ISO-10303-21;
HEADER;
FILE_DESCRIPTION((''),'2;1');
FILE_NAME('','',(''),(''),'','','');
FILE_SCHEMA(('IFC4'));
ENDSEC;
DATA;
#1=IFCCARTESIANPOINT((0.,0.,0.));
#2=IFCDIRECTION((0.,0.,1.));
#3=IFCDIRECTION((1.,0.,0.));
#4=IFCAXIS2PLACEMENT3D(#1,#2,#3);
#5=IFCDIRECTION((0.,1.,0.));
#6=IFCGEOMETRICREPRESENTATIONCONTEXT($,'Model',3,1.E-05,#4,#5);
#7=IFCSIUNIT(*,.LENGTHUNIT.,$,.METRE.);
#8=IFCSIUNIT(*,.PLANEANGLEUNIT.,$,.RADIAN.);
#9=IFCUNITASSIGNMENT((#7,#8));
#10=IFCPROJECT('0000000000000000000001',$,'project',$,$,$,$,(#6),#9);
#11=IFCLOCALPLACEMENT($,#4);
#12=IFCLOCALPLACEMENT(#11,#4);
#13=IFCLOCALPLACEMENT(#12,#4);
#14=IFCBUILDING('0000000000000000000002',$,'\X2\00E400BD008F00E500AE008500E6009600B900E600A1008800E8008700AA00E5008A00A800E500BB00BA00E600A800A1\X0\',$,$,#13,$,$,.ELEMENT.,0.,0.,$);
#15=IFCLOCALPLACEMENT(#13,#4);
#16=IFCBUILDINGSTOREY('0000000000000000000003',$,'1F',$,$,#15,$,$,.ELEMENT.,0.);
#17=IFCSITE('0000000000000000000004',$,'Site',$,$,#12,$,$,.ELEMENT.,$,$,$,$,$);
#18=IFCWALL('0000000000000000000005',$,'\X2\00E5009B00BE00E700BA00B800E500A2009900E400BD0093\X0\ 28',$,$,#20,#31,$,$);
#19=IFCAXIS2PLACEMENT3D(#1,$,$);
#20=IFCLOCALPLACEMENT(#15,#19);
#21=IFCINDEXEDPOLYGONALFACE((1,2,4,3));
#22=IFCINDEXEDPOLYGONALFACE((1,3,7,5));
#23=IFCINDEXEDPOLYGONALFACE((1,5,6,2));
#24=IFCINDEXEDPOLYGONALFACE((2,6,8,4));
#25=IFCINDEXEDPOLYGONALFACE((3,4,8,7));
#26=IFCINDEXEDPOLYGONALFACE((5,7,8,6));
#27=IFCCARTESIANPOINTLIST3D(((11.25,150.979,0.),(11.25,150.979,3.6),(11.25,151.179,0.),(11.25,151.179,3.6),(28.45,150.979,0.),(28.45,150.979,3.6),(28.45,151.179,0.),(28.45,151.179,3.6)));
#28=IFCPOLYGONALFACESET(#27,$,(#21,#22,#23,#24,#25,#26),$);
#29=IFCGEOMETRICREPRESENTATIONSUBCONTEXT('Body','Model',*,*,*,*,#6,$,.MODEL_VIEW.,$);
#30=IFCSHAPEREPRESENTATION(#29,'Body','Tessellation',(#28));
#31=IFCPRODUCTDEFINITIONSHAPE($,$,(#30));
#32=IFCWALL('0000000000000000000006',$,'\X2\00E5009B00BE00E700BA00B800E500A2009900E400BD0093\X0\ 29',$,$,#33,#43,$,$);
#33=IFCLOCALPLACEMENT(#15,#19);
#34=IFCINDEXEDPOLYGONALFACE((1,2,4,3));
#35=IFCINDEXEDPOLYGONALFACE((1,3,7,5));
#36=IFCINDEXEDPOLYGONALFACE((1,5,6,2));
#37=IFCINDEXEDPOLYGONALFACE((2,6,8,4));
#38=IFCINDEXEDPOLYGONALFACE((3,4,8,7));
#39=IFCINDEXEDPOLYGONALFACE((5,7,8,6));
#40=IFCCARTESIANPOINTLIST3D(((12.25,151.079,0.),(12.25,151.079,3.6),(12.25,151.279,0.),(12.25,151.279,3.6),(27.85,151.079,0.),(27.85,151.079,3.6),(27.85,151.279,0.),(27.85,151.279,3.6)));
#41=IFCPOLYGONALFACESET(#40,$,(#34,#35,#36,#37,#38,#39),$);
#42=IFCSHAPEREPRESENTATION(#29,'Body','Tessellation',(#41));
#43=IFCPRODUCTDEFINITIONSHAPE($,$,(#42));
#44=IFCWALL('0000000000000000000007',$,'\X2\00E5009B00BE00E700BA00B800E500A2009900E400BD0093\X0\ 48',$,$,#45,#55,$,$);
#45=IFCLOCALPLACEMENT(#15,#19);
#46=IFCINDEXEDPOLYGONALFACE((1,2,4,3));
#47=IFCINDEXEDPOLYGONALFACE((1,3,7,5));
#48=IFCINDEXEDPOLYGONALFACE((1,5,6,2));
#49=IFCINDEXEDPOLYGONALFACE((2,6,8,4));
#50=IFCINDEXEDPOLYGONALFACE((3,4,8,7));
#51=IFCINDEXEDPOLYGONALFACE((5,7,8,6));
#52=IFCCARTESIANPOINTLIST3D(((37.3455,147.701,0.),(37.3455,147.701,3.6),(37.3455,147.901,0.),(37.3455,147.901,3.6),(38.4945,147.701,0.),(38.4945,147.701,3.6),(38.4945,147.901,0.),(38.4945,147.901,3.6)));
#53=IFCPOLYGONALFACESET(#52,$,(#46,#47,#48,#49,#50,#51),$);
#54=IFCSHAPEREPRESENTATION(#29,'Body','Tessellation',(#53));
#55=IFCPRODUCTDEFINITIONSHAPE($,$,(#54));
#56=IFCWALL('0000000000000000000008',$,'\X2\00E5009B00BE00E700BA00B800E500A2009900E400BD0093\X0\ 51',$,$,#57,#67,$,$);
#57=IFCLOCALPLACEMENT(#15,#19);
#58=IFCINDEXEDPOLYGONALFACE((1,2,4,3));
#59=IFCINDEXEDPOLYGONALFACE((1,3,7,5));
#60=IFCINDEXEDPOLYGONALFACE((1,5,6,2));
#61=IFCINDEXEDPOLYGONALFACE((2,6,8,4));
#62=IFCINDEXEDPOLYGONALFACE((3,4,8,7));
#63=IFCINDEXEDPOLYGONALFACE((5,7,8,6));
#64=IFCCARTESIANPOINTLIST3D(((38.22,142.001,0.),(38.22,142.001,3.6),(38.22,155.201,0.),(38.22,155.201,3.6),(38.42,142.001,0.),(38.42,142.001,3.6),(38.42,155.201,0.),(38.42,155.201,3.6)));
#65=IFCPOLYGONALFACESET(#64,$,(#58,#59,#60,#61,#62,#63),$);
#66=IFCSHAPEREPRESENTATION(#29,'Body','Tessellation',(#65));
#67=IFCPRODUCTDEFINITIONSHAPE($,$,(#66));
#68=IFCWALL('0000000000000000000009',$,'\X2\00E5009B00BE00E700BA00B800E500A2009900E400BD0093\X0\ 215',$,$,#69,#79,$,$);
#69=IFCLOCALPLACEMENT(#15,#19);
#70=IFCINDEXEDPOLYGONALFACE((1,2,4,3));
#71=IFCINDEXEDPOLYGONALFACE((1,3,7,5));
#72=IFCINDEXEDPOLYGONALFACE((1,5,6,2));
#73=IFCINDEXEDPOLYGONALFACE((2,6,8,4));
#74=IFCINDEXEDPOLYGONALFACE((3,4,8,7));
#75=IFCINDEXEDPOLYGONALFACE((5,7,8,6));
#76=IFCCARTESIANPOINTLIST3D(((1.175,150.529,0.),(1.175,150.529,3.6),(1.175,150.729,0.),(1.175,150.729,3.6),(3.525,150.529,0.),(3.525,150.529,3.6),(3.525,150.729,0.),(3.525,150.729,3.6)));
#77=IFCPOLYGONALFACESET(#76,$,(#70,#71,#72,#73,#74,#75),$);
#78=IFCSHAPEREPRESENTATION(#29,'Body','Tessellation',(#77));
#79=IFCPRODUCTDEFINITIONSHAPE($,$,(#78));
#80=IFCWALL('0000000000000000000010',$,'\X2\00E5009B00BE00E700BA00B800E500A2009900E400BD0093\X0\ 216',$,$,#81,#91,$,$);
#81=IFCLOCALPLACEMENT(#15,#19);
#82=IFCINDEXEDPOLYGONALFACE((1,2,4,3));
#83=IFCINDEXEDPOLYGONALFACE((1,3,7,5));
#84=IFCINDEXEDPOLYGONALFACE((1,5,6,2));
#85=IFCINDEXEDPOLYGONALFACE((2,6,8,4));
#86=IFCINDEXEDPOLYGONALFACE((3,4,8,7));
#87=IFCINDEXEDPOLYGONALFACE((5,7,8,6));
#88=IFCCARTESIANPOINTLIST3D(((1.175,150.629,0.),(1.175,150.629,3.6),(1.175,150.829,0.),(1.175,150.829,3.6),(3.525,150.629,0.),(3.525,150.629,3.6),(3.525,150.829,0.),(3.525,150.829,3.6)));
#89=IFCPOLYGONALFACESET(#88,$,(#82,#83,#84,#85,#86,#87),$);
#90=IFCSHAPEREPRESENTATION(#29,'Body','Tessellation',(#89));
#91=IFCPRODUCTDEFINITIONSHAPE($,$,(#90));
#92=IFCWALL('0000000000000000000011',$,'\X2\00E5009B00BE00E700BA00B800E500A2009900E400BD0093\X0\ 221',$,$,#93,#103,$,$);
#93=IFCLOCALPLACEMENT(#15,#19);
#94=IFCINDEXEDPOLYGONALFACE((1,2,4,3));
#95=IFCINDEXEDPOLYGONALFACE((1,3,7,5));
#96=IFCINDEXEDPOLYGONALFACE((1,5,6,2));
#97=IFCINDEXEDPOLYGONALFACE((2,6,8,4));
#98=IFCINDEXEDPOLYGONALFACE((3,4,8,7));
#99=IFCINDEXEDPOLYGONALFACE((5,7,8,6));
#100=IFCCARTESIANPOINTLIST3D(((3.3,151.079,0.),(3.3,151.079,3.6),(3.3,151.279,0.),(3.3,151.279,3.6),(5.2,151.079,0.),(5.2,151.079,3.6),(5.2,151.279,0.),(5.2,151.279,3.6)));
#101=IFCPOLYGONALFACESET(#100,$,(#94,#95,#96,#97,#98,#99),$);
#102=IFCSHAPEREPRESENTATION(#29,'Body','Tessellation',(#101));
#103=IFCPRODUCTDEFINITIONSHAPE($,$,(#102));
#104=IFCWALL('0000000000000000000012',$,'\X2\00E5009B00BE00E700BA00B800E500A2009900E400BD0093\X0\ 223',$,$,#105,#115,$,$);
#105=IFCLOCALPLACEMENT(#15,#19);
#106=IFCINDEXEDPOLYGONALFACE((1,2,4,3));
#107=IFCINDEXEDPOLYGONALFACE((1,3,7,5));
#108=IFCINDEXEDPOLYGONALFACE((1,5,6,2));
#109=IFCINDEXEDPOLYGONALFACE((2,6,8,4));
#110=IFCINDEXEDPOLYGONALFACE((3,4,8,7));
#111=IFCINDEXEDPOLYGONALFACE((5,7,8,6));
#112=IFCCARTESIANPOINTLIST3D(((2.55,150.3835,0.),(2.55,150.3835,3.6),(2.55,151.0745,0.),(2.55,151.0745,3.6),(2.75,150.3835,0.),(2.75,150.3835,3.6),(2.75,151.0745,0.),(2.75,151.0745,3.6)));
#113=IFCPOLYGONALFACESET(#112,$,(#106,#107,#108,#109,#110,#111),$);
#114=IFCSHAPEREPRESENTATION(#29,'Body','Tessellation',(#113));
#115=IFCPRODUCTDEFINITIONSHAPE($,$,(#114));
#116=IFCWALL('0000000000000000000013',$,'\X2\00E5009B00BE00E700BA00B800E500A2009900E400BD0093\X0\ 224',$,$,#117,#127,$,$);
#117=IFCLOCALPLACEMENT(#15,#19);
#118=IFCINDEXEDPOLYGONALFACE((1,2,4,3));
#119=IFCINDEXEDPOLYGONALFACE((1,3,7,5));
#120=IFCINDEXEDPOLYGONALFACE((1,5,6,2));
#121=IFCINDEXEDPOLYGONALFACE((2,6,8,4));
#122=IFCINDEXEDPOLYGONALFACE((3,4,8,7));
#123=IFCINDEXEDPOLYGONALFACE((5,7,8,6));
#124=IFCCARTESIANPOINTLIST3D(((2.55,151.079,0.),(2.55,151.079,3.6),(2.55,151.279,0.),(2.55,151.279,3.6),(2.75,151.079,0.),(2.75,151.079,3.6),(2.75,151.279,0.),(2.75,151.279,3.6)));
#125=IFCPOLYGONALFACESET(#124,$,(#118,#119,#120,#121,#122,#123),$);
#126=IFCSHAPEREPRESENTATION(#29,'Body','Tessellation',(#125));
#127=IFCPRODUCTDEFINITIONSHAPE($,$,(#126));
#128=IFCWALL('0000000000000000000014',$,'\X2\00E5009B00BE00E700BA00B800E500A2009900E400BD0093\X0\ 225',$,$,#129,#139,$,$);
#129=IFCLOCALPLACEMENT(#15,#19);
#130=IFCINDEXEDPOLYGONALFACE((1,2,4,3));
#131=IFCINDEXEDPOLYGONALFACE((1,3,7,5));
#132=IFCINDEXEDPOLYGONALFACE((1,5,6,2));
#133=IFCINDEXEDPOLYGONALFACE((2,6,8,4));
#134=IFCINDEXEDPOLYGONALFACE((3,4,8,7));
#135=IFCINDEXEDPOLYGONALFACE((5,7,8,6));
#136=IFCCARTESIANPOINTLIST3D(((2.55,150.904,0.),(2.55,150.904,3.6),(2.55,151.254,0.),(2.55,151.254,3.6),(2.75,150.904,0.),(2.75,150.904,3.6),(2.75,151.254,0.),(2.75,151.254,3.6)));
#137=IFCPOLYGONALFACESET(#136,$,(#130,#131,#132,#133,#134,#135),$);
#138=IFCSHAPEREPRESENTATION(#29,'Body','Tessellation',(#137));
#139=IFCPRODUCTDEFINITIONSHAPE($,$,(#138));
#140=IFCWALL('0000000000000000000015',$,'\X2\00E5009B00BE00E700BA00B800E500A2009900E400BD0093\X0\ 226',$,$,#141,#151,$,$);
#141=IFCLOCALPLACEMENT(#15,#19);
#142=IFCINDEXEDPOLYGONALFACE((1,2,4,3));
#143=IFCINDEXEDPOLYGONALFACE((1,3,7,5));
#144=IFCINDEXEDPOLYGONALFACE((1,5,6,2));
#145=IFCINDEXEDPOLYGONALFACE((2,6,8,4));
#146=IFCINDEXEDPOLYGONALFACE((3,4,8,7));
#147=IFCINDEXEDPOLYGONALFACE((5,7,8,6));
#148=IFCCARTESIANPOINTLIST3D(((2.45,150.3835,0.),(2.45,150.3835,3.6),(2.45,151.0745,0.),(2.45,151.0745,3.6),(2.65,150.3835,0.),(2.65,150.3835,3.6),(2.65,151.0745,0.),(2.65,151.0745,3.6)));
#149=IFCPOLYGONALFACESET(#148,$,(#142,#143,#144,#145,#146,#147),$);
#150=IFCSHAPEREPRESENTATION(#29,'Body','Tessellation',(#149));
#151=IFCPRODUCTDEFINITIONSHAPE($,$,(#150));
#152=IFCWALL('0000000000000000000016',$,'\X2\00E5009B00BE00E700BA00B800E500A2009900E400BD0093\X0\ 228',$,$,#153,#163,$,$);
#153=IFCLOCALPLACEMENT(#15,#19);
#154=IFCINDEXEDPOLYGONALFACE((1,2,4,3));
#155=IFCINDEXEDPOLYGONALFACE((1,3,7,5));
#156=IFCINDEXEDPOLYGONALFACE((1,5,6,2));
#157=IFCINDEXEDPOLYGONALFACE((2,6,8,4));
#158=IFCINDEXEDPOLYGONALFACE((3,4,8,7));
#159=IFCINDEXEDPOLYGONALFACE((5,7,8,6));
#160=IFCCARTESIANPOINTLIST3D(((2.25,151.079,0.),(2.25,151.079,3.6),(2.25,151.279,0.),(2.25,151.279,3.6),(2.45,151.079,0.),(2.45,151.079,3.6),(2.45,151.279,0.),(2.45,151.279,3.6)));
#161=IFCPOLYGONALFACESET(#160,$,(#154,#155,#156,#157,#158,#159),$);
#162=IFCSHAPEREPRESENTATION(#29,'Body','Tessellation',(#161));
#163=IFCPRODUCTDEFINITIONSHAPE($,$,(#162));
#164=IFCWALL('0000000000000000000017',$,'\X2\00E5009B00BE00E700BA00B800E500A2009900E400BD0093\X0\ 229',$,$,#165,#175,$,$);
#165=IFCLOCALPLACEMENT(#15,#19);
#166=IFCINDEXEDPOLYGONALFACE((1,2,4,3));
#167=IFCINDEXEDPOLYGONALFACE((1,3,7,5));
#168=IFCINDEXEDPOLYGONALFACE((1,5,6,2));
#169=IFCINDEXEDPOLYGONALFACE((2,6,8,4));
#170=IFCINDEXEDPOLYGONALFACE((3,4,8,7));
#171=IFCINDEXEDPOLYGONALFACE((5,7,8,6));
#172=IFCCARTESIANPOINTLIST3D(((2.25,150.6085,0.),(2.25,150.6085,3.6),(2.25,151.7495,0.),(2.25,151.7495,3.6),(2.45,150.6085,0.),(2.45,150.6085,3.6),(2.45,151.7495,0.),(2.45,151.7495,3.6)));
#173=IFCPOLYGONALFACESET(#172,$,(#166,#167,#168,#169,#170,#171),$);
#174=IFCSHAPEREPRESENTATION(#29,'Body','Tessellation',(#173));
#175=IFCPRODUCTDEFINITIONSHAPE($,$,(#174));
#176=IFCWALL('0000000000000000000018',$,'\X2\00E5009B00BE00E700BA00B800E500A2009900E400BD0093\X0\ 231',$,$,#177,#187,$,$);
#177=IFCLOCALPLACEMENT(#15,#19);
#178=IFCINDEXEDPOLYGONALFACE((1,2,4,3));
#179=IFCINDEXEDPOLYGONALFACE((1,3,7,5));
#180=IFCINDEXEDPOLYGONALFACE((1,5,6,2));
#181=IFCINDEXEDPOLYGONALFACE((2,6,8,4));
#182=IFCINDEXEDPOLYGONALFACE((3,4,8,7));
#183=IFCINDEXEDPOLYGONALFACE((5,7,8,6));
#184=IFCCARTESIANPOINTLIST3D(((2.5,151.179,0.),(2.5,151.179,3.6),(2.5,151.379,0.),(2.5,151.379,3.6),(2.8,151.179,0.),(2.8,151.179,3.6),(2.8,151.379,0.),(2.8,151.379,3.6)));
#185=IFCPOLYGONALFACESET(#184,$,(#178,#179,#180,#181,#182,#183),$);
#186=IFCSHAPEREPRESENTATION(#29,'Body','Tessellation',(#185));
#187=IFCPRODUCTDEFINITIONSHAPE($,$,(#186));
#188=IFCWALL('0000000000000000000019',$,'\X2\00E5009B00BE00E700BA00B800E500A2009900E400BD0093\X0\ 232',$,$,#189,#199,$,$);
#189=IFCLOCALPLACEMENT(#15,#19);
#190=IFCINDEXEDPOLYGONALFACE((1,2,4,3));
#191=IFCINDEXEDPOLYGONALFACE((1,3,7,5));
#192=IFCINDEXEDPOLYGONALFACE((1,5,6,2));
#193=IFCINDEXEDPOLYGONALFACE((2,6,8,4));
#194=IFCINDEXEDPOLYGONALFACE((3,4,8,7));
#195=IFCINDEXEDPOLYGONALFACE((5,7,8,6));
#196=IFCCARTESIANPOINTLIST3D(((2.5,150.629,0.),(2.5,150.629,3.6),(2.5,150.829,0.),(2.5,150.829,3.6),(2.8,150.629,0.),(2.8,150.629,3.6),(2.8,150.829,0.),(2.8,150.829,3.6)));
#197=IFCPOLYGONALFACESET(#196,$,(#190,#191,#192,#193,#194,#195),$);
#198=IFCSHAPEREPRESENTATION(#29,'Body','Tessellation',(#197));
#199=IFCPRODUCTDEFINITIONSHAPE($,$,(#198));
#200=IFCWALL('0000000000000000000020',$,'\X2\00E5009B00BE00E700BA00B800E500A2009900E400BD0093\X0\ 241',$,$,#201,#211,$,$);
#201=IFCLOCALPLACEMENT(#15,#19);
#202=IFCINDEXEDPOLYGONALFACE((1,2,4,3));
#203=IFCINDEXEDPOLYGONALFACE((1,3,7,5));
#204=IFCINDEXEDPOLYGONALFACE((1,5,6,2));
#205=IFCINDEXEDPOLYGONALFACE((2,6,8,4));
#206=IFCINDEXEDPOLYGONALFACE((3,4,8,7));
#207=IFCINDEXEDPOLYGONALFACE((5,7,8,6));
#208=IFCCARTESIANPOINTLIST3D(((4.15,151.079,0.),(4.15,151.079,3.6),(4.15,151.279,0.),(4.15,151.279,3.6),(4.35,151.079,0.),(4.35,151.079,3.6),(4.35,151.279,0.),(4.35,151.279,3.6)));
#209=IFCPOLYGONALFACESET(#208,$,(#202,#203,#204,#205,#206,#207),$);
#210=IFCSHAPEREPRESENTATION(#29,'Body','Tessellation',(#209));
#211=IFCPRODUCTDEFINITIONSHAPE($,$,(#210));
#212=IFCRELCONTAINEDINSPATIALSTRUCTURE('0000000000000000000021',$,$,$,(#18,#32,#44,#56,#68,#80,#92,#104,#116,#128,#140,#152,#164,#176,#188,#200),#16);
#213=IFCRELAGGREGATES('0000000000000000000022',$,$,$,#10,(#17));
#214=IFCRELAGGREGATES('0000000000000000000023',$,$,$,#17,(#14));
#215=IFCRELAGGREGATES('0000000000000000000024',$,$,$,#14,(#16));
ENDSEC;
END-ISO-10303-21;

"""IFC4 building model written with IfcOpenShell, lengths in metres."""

from ifc_helpers import new_model, si_unit, direction, frame, frame_2d, origin_with_axes, place, context, subcontext, project, spatial, rectangle, extrude, element, save


model = new_model("IFC4")

# Units and contexts
model_context = context("Model", 3, precision=1e-05, world=origin_with_axes(), true_north=direction((0.0, 1.0, 0.0)))
body_context = subcontext(model_context, "Body", "Model", "MODEL_VIEW")
ifc_project = project(units=[si_unit("LENGTHUNIT", "METRE"), si_unit("PLANEANGLEUNIT", "RADIAN")], contexts=[model_context])

# Site, building, storey
placement = place(None, origin_with_axes())
site_placement = place(placement, origin_with_axes())
site = spatial("IfcSite", under=ifc_project, at=site_placement, Name="Site", CompositionType="ELEMENT")
building_placement = place(site_placement, origin_with_axes())
building = spatial("IfcBuilding", under=site, at=building_placement, Name="ä½\u008få®\u0085æ\u0096¹æ¡\u0088è\u0087ªå\u008a¨å»ºæ¨¡", CompositionType="ELEMENT", ElevationOfRefHeight=0.0, ElevationOfTerrain=0.0)
storey_placement = place(building_placement, origin_with_axes())
storey = spatial("IfcBuildingStorey", under=building, at=storey_placement, Name="1F", CompositionType="ELEMENT", Elevation=0.0)

# Walls
wall_1_placement = place(storey_placement, frame((19.85, 151.079, 0.0), z_axis=(0.0, 0.0, 1.0), x_axis=(-1.0, 0.0, 0.0)))
element("IfcWall", 1, at=wall_1_placement, inside=storey, Name="å\u009b¾çº¸å¢\u0099ä½\u0093 28", context=body_context, shape_type="SweptSolid", body=[
    extrude(rectangle(XDim=17.2, YDim=0.2, at=frame_2d((0.0, 0.0), x_axis=(1.0, 0.0, 0.0))), frame((0.0, 0.0, 0.0), z_axis=(0.0, 0.0, 1.0)), (0.0, 0.0, 1.0), 3.6),
])
wall_2_placement = place(storey_placement, frame((20.05, 151.179, 0.0), z_axis=(0.0, 0.0, 1.0), x_axis=(-1.0, 0.0, 0.0)))
element("IfcWall", 2, at=wall_2_placement, inside=storey, Name="å\u009b¾çº¸å¢\u0099ä½\u0093 29", context=body_context, shape_type="SweptSolid", body=[
    extrude(rectangle(XDim=15.6, YDim=0.2, at=frame_2d((0.0, 0.0), x_axis=(1.0, 0.0, 0.0))), frame((0.0, 0.0, 0.0), z_axis=(0.0, 0.0, 1.0)), (0.0, 0.0, 1.0), 3.6),
])
wall_3_placement = place(storey_placement, frame((37.92, 147.801, 0.0), z_axis=(0.0, 0.0, 1.0), x_axis=(-1.0, 0.0, 0.0)))
element("IfcWall", 3, at=wall_3_placement, inside=storey, Name="å\u009b¾çº¸å¢\u0099ä½\u0093 48", context=body_context, shape_type="SweptSolid", body=[
    extrude(rectangle(XDim=1.149, YDim=0.2, at=frame_2d((0.0, 0.0), x_axis=(1.0, 0.0, 0.0))), frame((0.0, 0.0, 0.0), z_axis=(0.0, 0.0, 1.0)), (0.0, 0.0, 1.0), 3.6),
])
wall_4_placement = place(storey_placement, frame((38.32, 148.601, 0.0), z_axis=(0.0, 0.0, 1.0), x_axis=(0.0, 1.0, 0.0)))
element("IfcWall", 4, at=wall_4_placement, inside=storey, Name="å\u009b¾çº¸å¢\u0099ä½\u0093 51", context=body_context, shape_type="SweptSolid", body=[
    extrude(rectangle(XDim=13.2, YDim=0.2, at=frame_2d((0.0, 0.0), x_axis=(1.0, 0.0, 0.0))), frame((0.0, 0.0, 0.0), z_axis=(0.0, 0.0, 1.0)), (0.0, 0.0, 1.0), 3.6),
])
for number, where, z_axis, x_axis, name in (
    (5, (2.35, 150.629, 0.0), (0.0, 0.0, 1.0), (-1.0, 0.0, 0.0), "å\u009b¾çº¸å¢\u0099ä½\u0093 215"),
    (6, (2.35, 150.729, 0.0), (0.0, 0.0, 1.0), (-1.0, 0.0, 0.0), "å\u009b¾çº¸å¢\u0099ä½\u0093 216"),
):
    element("IfcWall", number, at=place(storey_placement, frame(where, z_axis=z_axis, x_axis=x_axis)), inside=storey, Name=name, context=body_context, shape_type="SweptSolid", body=[
        extrude(rectangle(XDim=2.35, YDim=0.2, at=frame_2d((0.0, 0.0), x_axis=(1.0, 0.0, 0.0))), frame((0.0, 0.0, 0.0), z_axis=(0.0, 0.0, 1.0)), (0.0, 0.0, 1.0), 3.6),
    ])
wall_5_placement = place(storey_placement, frame((4.25, 151.179, 0.0), z_axis=(0.0, 0.0, 1.0), x_axis=(-1.0, 0.0, 0.0)))
element("IfcWall", 7, at=wall_5_placement, inside=storey, Name="å\u009b¾çº¸å¢\u0099ä½\u0093 221", context=body_context, shape_type="SweptSolid", body=[
    extrude(rectangle(XDim=1.9, YDim=0.2, at=frame_2d((0.0, 0.0), x_axis=(1.0, 0.0, 0.0))), frame((0.0, 0.0, 0.0), z_axis=(0.0, 0.0, 1.0)), (0.0, 0.0, 1.0), 3.6),
])
wall_6_placement = place(storey_placement, frame((2.65, 150.729, 0.0), z_axis=(0.0, 0.0, 1.0), x_axis=(0.0, -1.0, 0.0)))
element("IfcWall", 8, at=wall_6_placement, inside=storey, Name="å\u009b¾çº¸å¢\u0099ä½\u0093 223", context=body_context, shape_type="SweptSolid", body=[
    extrude(rectangle(XDim=0.691, YDim=0.2, at=frame_2d((0.0, 0.0), x_axis=(1.0, 0.0, 0.0))), frame((0.0, 0.0, 0.0), z_axis=(0.0, 0.0, 1.0)), (0.0, 0.0, 1.0), 3.6),
])
wall_7_placement = place(storey_placement, frame((2.65, 151.179, 0.0), z_axis=(0.0, 0.0, 1.0), x_axis=(0.0, 1.0, 0.0)))
element("IfcWall", 9, at=wall_7_placement, inside=storey, Name="å\u009b¾çº¸å¢\u0099ä½\u0093 224", context=body_context, shape_type="SweptSolid", body=[
    extrude(rectangle(XDim=0.2, YDim=0.2, at=frame_2d((0.0, 0.0), x_axis=(1.0, 0.0, 0.0))), frame((0.0, 0.0, 0.0), z_axis=(0.0, 0.0, 1.0)), (0.0, 0.0, 1.0), 3.6),
])
wall_8_placement = place(storey_placement, frame((2.65, 151.079, 0.0), z_axis=(0.0, 0.0, 1.0), x_axis=(0.0, -1.0, 0.0)))
element("IfcWall", 10, at=wall_8_placement, inside=storey, Name="å\u009b¾çº¸å¢\u0099ä½\u0093 225", context=body_context, shape_type="SweptSolid", body=[
    extrude(rectangle(XDim=0.35, YDim=0.2, at=frame_2d((0.0, 0.0), x_axis=(1.0, 0.0, 0.0))), frame((0.0, 0.0, 0.0), z_axis=(0.0, 0.0, 1.0)), (0.0, 0.0, 1.0), 3.6),
])
wall_9_placement = place(storey_placement, frame((2.55, 150.729, 0.0), z_axis=(0.0, 0.0, 1.0), x_axis=(0.0, -1.0, 0.0)))
element("IfcWall", 11, at=wall_9_placement, inside=storey, Name="å\u009b¾çº¸å¢\u0099ä½\u0093 226", context=body_context, shape_type="SweptSolid", body=[
    extrude(rectangle(XDim=0.691, YDim=0.2, at=frame_2d((0.0, 0.0), x_axis=(1.0, 0.0, 0.0))), frame((0.0, 0.0, 0.0), z_axis=(0.0, 0.0, 1.0)), (0.0, 0.0, 1.0), 3.6),
])
wall_10_placement = place(storey_placement, frame((2.35, 151.179, 0.0), z_axis=(0.0, 0.0, 1.0), x_axis=(0.0, 1.0, 0.0)))
element("IfcWall", 12, at=wall_10_placement, inside=storey, Name="å\u009b¾çº¸å¢\u0099ä½\u0093 228", context=body_context, shape_type="SweptSolid", body=[
    extrude(rectangle(XDim=0.2, YDim=0.2, at=frame_2d((0.0, 0.0), x_axis=(1.0, 0.0, 0.0))), frame((0.0, 0.0, 0.0), z_axis=(0.0, 0.0, 1.0)), (0.0, 0.0, 1.0), 3.6),
])
wall_11_placement = place(storey_placement, frame((2.35, 151.179, 0.0), z_axis=(0.0, 0.0, 1.0), x_axis=(0.0, -1.0, 0.0)))
element("IfcWall", 13, at=wall_11_placement, inside=storey, Name="å\u009b¾çº¸å¢\u0099ä½\u0093 229", context=body_context, shape_type="SweptSolid", body=[
    extrude(rectangle(XDim=1.141, YDim=0.2, at=frame_2d((0.0, 0.0), x_axis=(1.0, 0.0, 0.0))), frame((0.0, 0.0, 0.0), z_axis=(0.0, 0.0, 1.0)), (0.0, 0.0, 1.0), 3.6),
])
for number, where, z_axis, x_axis, name in (
    (14, (2.65, 151.279, 0.0), (0.0, 0.0, 1.0), (-1.0, 0.0, 0.0), "å\u009b¾çº¸å¢\u0099ä½\u0093 231"),
    (15, (2.65, 150.729, 0.0), (0.0, 0.0, 1.0), (-1.0, 0.0, 0.0), "å\u009b¾çº¸å¢\u0099ä½\u0093 232"),
):
    element("IfcWall", number, at=place(storey_placement, frame(where, z_axis=z_axis, x_axis=x_axis)), inside=storey, Name=name, context=body_context, shape_type="SweptSolid", body=[
        extrude(rectangle(XDim=0.3, YDim=0.2, at=frame_2d((0.0, 0.0), x_axis=(1.0, 0.0, 0.0))), frame((0.0, 0.0, 0.0), z_axis=(0.0, 0.0, 1.0)), (0.0, 0.0, 1.0), 3.6),
    ])
for number, where, z_axis, x_axis, name in (
    (16, (4.25, 151.179, 0.0), (0.0, 0.0, 1.0), (1.0, 0.0, 0.0), "å\u009b¾çº¸å¢\u0099ä½\u0093 241"),
):
    element("IfcWall", number, at=place(storey_placement, frame(where, z_axis=z_axis, x_axis=x_axis)), inside=storey, Name=name, context=body_context, shape_type="SweptSolid", body=[
        extrude(rectangle(XDim=0.2, YDim=0.2, at=frame_2d((0.0, 0.0), x_axis=(1.0, 0.0, 0.0))), frame((0.0, 0.0, 0.0), z_axis=(0.0, 0.0, 1.0)), (0.0, 0.0, 1.0), 3.6),
    ])

save(model, "model.ifc")
